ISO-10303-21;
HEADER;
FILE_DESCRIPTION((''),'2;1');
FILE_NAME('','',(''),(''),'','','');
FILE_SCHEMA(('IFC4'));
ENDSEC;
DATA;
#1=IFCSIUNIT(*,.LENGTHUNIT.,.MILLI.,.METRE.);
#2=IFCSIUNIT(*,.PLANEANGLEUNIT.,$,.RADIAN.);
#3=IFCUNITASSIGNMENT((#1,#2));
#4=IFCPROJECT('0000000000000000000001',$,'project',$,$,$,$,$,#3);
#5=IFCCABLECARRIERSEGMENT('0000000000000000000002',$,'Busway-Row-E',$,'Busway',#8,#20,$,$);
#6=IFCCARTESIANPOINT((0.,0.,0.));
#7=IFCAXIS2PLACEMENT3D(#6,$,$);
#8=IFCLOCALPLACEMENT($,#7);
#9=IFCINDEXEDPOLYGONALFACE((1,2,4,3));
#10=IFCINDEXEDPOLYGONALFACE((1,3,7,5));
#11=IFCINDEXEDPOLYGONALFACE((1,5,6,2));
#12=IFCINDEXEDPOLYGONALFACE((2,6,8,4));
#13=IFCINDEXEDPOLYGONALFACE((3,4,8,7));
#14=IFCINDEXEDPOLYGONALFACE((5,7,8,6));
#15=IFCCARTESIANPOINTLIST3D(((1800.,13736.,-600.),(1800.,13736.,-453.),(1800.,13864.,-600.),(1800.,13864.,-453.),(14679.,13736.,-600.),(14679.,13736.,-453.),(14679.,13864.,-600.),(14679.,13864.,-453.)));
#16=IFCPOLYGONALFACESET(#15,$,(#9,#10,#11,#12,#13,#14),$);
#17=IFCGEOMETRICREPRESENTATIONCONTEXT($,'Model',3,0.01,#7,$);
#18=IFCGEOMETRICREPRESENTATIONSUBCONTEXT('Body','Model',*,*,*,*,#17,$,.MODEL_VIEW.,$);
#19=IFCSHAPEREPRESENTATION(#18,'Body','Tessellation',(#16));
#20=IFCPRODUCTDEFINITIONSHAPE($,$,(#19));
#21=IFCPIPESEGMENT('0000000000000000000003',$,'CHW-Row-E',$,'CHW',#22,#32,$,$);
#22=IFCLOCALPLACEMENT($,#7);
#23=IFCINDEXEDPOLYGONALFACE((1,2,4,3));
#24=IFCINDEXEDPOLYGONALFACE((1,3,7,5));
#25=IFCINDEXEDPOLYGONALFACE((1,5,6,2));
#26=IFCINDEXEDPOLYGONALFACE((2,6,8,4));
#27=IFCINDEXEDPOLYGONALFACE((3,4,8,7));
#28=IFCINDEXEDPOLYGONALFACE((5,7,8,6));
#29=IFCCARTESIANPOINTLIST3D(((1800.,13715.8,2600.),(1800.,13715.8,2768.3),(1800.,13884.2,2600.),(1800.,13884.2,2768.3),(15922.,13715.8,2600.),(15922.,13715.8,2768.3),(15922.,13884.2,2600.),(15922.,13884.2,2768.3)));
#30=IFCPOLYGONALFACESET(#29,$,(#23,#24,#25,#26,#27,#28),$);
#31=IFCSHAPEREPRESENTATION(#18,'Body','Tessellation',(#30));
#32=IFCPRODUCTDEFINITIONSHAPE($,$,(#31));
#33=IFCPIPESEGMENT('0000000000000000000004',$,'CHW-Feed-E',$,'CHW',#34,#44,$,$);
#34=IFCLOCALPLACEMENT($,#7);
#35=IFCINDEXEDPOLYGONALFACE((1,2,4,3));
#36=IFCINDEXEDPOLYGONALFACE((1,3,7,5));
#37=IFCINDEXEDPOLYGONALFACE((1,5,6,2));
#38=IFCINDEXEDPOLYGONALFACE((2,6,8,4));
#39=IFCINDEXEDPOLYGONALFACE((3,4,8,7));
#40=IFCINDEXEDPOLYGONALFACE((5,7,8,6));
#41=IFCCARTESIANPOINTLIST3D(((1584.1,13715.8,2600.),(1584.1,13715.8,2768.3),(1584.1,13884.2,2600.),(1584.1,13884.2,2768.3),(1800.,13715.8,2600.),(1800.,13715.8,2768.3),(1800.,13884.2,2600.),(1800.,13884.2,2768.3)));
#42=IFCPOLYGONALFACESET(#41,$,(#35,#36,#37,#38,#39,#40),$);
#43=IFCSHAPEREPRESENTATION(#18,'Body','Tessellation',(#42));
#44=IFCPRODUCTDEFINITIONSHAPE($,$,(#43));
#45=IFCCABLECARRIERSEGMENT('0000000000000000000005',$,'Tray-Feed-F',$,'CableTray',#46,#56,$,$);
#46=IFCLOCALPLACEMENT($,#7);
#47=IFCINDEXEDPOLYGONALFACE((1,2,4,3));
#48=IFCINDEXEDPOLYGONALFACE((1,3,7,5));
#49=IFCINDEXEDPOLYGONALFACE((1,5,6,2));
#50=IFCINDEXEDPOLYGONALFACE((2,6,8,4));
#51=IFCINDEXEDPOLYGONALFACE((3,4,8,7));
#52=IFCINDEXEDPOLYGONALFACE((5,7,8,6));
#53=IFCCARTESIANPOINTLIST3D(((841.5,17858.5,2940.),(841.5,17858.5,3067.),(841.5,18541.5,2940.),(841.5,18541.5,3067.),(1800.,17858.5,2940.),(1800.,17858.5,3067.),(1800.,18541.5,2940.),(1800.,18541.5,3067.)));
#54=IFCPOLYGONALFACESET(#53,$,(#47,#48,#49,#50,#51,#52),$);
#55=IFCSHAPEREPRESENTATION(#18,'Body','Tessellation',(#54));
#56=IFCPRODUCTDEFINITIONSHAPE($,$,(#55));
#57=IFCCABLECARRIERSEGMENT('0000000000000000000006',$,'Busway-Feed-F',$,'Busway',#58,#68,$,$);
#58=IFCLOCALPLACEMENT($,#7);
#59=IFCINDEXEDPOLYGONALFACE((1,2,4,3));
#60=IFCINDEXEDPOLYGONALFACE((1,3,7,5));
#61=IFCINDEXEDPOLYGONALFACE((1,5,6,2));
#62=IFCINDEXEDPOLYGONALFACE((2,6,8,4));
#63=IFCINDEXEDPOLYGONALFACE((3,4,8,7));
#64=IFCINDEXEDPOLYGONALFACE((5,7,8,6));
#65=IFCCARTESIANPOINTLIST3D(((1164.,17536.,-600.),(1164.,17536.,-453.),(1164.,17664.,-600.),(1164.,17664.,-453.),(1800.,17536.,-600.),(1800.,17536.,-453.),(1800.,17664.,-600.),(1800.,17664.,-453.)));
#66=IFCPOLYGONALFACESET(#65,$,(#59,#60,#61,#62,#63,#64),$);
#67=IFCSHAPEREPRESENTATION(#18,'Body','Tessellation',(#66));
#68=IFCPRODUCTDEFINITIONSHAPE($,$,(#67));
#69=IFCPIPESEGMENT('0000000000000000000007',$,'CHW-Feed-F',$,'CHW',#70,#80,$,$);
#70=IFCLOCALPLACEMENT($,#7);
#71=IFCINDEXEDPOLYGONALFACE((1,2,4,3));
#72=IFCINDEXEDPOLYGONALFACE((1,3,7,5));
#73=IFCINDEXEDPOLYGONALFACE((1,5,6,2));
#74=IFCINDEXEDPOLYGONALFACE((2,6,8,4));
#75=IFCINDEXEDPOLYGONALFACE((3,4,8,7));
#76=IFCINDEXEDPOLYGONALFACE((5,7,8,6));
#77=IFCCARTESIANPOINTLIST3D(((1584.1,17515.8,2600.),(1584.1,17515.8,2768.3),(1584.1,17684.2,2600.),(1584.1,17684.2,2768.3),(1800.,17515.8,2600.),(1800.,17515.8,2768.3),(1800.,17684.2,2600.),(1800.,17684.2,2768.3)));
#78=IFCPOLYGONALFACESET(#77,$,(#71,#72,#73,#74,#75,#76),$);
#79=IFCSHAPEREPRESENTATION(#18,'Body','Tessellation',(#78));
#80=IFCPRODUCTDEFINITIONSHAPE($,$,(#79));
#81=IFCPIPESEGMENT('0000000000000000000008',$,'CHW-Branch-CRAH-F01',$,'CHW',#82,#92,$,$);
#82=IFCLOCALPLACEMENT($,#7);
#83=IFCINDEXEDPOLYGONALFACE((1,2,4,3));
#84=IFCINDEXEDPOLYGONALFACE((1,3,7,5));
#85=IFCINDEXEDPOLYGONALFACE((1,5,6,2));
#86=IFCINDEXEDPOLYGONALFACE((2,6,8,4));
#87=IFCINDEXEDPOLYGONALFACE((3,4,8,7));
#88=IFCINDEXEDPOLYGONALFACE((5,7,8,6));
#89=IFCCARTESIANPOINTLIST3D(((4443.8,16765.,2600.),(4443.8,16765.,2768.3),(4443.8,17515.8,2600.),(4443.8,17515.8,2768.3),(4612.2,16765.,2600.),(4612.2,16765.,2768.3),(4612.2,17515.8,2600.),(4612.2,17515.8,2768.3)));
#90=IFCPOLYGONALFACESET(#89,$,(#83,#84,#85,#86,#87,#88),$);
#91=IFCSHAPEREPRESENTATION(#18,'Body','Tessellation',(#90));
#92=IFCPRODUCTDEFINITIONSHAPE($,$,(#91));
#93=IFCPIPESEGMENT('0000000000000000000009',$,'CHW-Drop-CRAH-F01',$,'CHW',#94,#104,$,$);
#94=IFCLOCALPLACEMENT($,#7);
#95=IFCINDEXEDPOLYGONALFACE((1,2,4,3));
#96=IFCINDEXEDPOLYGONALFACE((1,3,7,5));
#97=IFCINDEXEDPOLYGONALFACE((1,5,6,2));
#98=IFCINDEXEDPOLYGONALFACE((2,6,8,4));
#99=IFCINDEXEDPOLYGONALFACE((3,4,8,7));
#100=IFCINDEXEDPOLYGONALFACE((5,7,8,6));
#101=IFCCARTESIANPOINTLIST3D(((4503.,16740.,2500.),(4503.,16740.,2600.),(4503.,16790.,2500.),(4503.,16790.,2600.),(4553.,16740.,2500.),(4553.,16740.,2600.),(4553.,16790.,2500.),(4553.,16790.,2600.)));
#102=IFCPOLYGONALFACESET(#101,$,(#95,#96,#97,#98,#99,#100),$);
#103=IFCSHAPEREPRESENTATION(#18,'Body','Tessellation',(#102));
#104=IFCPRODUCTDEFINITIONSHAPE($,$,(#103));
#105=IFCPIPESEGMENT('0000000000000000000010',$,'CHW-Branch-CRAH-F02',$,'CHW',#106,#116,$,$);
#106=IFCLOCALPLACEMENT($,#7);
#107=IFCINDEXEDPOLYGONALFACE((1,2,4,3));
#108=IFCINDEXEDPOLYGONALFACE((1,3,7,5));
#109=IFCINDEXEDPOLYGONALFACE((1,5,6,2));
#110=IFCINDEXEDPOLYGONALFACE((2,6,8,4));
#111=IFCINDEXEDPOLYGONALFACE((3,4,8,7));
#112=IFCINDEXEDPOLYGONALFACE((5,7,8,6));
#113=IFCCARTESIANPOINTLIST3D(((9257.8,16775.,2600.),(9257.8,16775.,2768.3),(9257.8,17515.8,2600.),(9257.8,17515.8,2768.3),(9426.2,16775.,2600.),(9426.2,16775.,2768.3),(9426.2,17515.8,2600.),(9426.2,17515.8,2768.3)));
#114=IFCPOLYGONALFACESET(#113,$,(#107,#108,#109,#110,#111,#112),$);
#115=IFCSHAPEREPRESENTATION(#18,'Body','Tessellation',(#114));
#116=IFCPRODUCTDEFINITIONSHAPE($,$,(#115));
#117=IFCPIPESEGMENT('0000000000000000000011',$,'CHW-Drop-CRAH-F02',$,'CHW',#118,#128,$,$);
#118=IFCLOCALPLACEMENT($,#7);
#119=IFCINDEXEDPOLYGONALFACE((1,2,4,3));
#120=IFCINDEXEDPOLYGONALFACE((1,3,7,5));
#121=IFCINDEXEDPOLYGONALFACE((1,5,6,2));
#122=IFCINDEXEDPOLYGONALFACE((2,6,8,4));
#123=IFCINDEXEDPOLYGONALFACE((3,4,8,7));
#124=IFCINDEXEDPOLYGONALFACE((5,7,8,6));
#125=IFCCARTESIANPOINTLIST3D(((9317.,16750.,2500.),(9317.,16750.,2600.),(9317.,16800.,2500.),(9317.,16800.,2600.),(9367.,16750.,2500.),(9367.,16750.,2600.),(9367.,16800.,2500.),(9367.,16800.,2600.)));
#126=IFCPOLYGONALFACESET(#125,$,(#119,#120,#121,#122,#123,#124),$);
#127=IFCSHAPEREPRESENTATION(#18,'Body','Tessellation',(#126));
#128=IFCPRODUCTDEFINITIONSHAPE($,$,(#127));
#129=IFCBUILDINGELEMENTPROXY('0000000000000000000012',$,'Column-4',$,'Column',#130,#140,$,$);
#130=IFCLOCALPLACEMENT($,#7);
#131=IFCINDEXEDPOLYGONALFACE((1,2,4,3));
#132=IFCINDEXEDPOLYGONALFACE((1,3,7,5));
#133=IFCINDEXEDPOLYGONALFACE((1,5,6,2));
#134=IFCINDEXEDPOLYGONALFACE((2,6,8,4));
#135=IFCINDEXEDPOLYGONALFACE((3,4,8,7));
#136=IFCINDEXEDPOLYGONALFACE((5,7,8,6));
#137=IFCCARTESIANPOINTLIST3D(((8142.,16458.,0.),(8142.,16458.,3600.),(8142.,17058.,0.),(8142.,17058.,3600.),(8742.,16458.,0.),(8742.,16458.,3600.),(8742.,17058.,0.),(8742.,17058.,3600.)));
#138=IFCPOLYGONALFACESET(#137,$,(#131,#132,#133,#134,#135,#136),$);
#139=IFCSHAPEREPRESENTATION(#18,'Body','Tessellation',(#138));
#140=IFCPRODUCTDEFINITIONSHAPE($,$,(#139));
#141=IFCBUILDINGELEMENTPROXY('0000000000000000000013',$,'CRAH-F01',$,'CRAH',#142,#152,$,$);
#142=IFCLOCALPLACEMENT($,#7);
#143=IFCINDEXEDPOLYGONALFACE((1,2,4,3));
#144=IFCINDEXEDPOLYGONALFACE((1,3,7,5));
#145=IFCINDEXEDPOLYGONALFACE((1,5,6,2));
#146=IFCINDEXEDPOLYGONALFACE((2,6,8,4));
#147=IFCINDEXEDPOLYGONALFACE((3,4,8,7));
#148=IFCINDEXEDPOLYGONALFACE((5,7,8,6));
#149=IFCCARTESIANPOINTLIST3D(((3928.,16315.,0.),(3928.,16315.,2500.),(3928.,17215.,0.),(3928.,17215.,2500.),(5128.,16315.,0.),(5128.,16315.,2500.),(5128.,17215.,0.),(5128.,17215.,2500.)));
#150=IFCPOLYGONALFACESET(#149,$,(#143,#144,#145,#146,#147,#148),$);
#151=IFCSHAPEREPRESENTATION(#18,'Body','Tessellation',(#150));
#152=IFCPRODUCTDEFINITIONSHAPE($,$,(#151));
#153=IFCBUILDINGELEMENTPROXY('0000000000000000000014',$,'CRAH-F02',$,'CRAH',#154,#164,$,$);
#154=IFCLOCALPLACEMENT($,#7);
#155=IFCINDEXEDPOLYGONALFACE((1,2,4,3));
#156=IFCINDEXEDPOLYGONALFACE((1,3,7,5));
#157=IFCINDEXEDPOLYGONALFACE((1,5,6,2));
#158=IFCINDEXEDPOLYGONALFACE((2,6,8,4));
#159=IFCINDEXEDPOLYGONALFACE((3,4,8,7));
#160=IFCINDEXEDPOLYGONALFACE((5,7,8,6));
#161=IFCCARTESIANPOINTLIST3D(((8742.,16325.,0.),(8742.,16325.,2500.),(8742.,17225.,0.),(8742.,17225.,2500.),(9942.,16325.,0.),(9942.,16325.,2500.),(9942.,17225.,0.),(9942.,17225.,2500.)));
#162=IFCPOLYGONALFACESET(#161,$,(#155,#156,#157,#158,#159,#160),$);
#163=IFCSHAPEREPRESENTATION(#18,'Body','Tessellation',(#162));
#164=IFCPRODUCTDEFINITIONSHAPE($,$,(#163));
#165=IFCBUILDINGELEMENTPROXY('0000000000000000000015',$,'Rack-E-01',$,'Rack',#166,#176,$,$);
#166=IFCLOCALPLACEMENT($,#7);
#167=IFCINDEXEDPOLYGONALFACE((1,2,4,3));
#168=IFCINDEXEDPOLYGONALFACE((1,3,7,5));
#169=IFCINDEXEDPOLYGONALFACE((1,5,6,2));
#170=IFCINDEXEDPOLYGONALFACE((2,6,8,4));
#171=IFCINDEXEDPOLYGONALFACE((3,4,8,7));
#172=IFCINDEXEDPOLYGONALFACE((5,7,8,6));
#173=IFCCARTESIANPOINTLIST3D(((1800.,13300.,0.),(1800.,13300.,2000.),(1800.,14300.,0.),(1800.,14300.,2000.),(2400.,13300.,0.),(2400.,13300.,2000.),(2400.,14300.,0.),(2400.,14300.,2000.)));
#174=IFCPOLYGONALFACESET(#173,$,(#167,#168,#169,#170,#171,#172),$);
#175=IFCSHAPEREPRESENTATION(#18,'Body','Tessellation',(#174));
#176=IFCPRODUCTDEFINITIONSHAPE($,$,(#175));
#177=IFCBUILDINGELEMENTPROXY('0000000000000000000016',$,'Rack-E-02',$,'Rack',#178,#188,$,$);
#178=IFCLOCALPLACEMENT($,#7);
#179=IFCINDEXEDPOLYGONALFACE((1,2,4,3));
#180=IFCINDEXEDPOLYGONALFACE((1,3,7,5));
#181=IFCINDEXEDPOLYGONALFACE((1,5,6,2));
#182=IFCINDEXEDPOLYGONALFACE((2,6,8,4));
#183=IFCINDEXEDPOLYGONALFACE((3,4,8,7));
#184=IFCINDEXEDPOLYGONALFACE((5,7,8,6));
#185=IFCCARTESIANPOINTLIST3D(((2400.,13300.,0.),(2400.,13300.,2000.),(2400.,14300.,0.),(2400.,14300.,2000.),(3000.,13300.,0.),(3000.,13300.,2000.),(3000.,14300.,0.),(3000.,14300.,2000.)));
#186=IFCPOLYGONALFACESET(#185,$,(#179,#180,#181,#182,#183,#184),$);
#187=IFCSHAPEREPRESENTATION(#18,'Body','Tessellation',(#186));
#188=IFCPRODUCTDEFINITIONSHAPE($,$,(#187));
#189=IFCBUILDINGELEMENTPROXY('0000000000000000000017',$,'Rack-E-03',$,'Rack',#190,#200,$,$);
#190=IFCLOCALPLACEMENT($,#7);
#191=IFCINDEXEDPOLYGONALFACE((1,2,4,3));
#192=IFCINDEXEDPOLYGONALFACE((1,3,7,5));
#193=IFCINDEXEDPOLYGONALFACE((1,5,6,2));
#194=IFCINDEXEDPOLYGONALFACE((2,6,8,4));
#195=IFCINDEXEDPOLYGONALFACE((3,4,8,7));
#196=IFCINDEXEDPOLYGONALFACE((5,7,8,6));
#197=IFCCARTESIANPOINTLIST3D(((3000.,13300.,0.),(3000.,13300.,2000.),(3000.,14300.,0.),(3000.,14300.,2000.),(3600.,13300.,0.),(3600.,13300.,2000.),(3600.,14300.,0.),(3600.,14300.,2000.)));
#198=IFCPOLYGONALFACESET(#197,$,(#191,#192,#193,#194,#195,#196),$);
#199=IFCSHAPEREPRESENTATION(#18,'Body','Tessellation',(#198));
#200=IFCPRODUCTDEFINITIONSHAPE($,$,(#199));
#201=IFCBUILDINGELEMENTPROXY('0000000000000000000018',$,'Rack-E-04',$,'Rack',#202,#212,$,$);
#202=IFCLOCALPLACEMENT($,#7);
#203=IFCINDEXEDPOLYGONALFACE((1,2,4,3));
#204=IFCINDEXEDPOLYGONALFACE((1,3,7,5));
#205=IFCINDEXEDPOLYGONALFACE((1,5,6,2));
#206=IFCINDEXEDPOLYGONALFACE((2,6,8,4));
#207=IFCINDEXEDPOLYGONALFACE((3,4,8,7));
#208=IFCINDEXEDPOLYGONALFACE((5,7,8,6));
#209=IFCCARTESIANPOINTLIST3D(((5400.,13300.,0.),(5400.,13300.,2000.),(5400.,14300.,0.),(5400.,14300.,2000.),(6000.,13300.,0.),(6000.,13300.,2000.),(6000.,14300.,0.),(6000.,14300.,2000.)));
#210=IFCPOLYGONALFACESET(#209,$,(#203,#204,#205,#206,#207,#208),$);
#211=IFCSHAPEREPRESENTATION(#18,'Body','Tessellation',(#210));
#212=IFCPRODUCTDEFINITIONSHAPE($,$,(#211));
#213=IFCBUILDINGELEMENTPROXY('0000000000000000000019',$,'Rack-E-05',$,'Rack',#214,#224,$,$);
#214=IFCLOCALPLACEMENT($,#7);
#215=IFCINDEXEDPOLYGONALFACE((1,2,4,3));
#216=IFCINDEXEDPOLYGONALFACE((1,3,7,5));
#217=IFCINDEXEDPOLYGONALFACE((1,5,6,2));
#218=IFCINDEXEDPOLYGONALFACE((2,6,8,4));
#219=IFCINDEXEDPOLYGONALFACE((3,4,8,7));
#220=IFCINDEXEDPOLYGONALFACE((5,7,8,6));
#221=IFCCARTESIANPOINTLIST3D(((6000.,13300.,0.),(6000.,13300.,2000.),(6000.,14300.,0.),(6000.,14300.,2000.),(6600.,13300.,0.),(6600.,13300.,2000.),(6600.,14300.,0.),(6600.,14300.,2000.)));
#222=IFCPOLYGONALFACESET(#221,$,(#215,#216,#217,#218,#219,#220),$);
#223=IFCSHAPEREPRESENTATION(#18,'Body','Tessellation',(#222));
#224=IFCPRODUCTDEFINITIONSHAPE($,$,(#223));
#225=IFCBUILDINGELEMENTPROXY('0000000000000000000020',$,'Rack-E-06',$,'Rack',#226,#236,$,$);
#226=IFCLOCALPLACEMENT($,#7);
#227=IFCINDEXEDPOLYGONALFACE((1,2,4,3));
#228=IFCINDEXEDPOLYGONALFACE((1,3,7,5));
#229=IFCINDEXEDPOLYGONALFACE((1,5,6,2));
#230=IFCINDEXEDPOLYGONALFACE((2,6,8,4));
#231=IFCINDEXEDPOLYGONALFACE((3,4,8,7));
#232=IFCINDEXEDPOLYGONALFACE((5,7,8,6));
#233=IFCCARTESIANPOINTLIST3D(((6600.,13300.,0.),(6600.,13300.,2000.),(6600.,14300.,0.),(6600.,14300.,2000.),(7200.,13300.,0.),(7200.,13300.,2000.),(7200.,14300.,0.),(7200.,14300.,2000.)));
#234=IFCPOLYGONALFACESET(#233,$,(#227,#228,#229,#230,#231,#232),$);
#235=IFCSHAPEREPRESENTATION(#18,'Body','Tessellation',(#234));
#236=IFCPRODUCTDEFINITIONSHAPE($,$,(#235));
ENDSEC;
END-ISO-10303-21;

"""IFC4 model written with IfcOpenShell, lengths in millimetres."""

from ifc_helpers import new_model, si_unit, frame, origin, place, context, subcontext, project, rectangle, extrude, element, save


model = new_model("IFC4")

# Units and contexts
model_context = context("Model", 3, precision=0.01, world=origin())
body_context = subcontext(model_context, "Body", "Model", "MODEL_VIEW")
ifc_project = project(units=[si_unit("LENGTHUNIT", "METRE", prefix="MILLI"), si_unit("PLANEANGLEUNIT", "RADIAN")])

# Cable carrier segment
placement = place(None, origin())
cable_carrier_segment_1_placement = place(placement, frame((8239.5, 13800.0, -600.0)))
element("IfcCableCarrierSegment", 1, at=cable_carrier_segment_1_placement, Name="Busway-Row-E", ObjectType="Busway", context=body_context, shape_type="SweptSolid", body=[
    extrude(rectangle(XDim=12879.0, YDim=128.0), origin(), (0.0, 0.0, 1.0), 147.0),
])

# Pipe segments
pipe_segment_1_placement = place(placement, frame((8861.0, 13800.0, 2600.0)))
element("IfcPipeSegment", 2, at=pipe_segment_1_placement, Name="CHW-Row-E", ObjectType="CHW", context=body_context, shape_type="SweptSolid", body=[
    extrude(rectangle(XDim=14122.0, YDim=168.3), origin(), (0.0, 0.0, 1.0), 168.3),
])
pipe_segment_2_placement = place(placement, frame((1692.1, 13800.0, 2600.0)))
element("IfcPipeSegment", 3, at=pipe_segment_2_placement, Name="CHW-Feed-E", ObjectType="CHW", context=body_context, shape_type="SweptSolid", body=[
    extrude(rectangle(XDim=215.8, YDim=168.3), origin(), (0.0, 0.0, 1.0), 168.3),
])

# Cable carrier segments
cable_carrier_segment_2_placement = place(placement, frame((1320.8, 18200.0, 2940.0)))
element("IfcCableCarrierSegment", 4, at=cable_carrier_segment_2_placement, Name="Tray-Feed-F", ObjectType="CableTray", context=body_context, shape_type="SweptSolid", body=[
    extrude(rectangle(XDim=958.5, YDim=683.0), origin(), (0.0, 0.0, 1.0), 127.0),
])
cable_carrier_segment_3_placement = place(placement, frame((1482.0, 17600.0, -600.0)))
element("IfcCableCarrierSegment", 5, at=cable_carrier_segment_3_placement, Name="Busway-Feed-F", ObjectType="Busway", context=body_context, shape_type="SweptSolid", body=[
    extrude(rectangle(XDim=636.0, YDim=128.0), origin(), (0.0, 0.0, 1.0), 147.0),
])

# Pipe segments
pipe_segment_3_placement = place(placement, frame((1692.1, 17600.0, 2600.0)))
element("IfcPipeSegment", 6, at=pipe_segment_3_placement, Name="CHW-Feed-F", ObjectType="CHW", context=body_context, shape_type="SweptSolid", body=[
    extrude(rectangle(XDim=215.8, YDim=168.3), origin(), (0.0, 0.0, 1.0), 168.3),
])
pipe_segment_4_placement = place(placement, frame((4528.0, 17140.4, 2600.0)))
element("IfcPipeSegment", 7, at=pipe_segment_4_placement, Name="CHW-Branch-CRAH-F01", ObjectType="CHW", context=body_context, shape_type="SweptSolid", body=[
    extrude(rectangle(XDim=168.3, YDim=750.8), origin(), (0.0, 0.0, 1.0), 168.3),
])
pipe_segment_5_placement = place(placement, frame((4528.0, 16765.0, 2500.0)))
element("IfcPipeSegment", 8, at=pipe_segment_5_placement, Name="CHW-Drop-CRAH-F01", ObjectType="CHW", context=body_context, shape_type="SweptSolid", body=[
    extrude(rectangle(XDim=50.0, YDim=50.0), origin(), (0.0, 0.0, 1.0), 100.0),
])
pipe_segment_6_placement = place(placement, frame((9342.0, 17145.4, 2600.0)))
element("IfcPipeSegment", 9, at=pipe_segment_6_placement, Name="CHW-Branch-CRAH-F02", ObjectType="CHW", context=body_context, shape_type="SweptSolid", body=[
    extrude(rectangle(XDim=168.3, YDim=740.8), origin(), (0.0, 0.0, 1.0), 168.3),
])
pipe_segment_7_placement = place(placement, frame((9342.0, 16775.0, 2500.0)))
element("IfcPipeSegment", 10, at=pipe_segment_7_placement, Name="CHW-Drop-CRAH-F02", ObjectType="CHW", context=body_context, shape_type="SweptSolid", body=[
    extrude(rectangle(XDim=50.0, YDim=50.0), origin(), (0.0, 0.0, 1.0), 100.0),
])

# Building element proxies
proxy_placement = place(placement, frame((8442.0, 16758.0, 0.0)))
element("IfcBuildingElementProxy", 11, at=proxy_placement, Name="Column-4", ObjectType="Column", context=body_context, shape_type="SweptSolid", body=[
    extrude(rectangle(XDim=600.0, YDim=600.0), origin(), (0.0, 0.0, 1.0), 3600.0),
])
for number, where, name in (
    (12, (4528.0, 16765.0, 0.0), "CRAH-F01"),
    (13, (9342.0, 16775.0, 0.0), "CRAH-F02"),
):
    element("IfcBuildingElementProxy", number, at=place(placement, frame(where)), Name=name, ObjectType="CRAH", context=body_context, shape_type="SweptSolid", body=[
        extrude(rectangle(XDim=1200.0, YDim=900.0), origin(), (0.0, 0.0, 1.0), 2500.0),
    ])
for number, where, name in (
    (14, (2100.0, 13800.0, 0.0), "Rack-E-01"),
    (15, (2700.0, 13800.0, 0.0), "Rack-E-02"),
    (16, (3300.0, 13800.0, 0.0), "Rack-E-03"),
    (17, (5700.0, 13800.0, 0.0), "Rack-E-04"),
    (18, (6300.0, 13800.0, 0.0), "Rack-E-05"),
    (19, (6900.0, 13800.0, 0.0), "Rack-E-06"),
):
    element("IfcBuildingElementProxy", number, at=place(placement, frame(where)), Name=name, ObjectType="Rack", context=body_context, shape_type="SweptSolid", body=[
        extrude(rectangle(XDim=600.0, YDim=1000.0), origin(), (0.0, 0.0, 1.0), 2000.0),
    ])

save(model, "model.ifc")
